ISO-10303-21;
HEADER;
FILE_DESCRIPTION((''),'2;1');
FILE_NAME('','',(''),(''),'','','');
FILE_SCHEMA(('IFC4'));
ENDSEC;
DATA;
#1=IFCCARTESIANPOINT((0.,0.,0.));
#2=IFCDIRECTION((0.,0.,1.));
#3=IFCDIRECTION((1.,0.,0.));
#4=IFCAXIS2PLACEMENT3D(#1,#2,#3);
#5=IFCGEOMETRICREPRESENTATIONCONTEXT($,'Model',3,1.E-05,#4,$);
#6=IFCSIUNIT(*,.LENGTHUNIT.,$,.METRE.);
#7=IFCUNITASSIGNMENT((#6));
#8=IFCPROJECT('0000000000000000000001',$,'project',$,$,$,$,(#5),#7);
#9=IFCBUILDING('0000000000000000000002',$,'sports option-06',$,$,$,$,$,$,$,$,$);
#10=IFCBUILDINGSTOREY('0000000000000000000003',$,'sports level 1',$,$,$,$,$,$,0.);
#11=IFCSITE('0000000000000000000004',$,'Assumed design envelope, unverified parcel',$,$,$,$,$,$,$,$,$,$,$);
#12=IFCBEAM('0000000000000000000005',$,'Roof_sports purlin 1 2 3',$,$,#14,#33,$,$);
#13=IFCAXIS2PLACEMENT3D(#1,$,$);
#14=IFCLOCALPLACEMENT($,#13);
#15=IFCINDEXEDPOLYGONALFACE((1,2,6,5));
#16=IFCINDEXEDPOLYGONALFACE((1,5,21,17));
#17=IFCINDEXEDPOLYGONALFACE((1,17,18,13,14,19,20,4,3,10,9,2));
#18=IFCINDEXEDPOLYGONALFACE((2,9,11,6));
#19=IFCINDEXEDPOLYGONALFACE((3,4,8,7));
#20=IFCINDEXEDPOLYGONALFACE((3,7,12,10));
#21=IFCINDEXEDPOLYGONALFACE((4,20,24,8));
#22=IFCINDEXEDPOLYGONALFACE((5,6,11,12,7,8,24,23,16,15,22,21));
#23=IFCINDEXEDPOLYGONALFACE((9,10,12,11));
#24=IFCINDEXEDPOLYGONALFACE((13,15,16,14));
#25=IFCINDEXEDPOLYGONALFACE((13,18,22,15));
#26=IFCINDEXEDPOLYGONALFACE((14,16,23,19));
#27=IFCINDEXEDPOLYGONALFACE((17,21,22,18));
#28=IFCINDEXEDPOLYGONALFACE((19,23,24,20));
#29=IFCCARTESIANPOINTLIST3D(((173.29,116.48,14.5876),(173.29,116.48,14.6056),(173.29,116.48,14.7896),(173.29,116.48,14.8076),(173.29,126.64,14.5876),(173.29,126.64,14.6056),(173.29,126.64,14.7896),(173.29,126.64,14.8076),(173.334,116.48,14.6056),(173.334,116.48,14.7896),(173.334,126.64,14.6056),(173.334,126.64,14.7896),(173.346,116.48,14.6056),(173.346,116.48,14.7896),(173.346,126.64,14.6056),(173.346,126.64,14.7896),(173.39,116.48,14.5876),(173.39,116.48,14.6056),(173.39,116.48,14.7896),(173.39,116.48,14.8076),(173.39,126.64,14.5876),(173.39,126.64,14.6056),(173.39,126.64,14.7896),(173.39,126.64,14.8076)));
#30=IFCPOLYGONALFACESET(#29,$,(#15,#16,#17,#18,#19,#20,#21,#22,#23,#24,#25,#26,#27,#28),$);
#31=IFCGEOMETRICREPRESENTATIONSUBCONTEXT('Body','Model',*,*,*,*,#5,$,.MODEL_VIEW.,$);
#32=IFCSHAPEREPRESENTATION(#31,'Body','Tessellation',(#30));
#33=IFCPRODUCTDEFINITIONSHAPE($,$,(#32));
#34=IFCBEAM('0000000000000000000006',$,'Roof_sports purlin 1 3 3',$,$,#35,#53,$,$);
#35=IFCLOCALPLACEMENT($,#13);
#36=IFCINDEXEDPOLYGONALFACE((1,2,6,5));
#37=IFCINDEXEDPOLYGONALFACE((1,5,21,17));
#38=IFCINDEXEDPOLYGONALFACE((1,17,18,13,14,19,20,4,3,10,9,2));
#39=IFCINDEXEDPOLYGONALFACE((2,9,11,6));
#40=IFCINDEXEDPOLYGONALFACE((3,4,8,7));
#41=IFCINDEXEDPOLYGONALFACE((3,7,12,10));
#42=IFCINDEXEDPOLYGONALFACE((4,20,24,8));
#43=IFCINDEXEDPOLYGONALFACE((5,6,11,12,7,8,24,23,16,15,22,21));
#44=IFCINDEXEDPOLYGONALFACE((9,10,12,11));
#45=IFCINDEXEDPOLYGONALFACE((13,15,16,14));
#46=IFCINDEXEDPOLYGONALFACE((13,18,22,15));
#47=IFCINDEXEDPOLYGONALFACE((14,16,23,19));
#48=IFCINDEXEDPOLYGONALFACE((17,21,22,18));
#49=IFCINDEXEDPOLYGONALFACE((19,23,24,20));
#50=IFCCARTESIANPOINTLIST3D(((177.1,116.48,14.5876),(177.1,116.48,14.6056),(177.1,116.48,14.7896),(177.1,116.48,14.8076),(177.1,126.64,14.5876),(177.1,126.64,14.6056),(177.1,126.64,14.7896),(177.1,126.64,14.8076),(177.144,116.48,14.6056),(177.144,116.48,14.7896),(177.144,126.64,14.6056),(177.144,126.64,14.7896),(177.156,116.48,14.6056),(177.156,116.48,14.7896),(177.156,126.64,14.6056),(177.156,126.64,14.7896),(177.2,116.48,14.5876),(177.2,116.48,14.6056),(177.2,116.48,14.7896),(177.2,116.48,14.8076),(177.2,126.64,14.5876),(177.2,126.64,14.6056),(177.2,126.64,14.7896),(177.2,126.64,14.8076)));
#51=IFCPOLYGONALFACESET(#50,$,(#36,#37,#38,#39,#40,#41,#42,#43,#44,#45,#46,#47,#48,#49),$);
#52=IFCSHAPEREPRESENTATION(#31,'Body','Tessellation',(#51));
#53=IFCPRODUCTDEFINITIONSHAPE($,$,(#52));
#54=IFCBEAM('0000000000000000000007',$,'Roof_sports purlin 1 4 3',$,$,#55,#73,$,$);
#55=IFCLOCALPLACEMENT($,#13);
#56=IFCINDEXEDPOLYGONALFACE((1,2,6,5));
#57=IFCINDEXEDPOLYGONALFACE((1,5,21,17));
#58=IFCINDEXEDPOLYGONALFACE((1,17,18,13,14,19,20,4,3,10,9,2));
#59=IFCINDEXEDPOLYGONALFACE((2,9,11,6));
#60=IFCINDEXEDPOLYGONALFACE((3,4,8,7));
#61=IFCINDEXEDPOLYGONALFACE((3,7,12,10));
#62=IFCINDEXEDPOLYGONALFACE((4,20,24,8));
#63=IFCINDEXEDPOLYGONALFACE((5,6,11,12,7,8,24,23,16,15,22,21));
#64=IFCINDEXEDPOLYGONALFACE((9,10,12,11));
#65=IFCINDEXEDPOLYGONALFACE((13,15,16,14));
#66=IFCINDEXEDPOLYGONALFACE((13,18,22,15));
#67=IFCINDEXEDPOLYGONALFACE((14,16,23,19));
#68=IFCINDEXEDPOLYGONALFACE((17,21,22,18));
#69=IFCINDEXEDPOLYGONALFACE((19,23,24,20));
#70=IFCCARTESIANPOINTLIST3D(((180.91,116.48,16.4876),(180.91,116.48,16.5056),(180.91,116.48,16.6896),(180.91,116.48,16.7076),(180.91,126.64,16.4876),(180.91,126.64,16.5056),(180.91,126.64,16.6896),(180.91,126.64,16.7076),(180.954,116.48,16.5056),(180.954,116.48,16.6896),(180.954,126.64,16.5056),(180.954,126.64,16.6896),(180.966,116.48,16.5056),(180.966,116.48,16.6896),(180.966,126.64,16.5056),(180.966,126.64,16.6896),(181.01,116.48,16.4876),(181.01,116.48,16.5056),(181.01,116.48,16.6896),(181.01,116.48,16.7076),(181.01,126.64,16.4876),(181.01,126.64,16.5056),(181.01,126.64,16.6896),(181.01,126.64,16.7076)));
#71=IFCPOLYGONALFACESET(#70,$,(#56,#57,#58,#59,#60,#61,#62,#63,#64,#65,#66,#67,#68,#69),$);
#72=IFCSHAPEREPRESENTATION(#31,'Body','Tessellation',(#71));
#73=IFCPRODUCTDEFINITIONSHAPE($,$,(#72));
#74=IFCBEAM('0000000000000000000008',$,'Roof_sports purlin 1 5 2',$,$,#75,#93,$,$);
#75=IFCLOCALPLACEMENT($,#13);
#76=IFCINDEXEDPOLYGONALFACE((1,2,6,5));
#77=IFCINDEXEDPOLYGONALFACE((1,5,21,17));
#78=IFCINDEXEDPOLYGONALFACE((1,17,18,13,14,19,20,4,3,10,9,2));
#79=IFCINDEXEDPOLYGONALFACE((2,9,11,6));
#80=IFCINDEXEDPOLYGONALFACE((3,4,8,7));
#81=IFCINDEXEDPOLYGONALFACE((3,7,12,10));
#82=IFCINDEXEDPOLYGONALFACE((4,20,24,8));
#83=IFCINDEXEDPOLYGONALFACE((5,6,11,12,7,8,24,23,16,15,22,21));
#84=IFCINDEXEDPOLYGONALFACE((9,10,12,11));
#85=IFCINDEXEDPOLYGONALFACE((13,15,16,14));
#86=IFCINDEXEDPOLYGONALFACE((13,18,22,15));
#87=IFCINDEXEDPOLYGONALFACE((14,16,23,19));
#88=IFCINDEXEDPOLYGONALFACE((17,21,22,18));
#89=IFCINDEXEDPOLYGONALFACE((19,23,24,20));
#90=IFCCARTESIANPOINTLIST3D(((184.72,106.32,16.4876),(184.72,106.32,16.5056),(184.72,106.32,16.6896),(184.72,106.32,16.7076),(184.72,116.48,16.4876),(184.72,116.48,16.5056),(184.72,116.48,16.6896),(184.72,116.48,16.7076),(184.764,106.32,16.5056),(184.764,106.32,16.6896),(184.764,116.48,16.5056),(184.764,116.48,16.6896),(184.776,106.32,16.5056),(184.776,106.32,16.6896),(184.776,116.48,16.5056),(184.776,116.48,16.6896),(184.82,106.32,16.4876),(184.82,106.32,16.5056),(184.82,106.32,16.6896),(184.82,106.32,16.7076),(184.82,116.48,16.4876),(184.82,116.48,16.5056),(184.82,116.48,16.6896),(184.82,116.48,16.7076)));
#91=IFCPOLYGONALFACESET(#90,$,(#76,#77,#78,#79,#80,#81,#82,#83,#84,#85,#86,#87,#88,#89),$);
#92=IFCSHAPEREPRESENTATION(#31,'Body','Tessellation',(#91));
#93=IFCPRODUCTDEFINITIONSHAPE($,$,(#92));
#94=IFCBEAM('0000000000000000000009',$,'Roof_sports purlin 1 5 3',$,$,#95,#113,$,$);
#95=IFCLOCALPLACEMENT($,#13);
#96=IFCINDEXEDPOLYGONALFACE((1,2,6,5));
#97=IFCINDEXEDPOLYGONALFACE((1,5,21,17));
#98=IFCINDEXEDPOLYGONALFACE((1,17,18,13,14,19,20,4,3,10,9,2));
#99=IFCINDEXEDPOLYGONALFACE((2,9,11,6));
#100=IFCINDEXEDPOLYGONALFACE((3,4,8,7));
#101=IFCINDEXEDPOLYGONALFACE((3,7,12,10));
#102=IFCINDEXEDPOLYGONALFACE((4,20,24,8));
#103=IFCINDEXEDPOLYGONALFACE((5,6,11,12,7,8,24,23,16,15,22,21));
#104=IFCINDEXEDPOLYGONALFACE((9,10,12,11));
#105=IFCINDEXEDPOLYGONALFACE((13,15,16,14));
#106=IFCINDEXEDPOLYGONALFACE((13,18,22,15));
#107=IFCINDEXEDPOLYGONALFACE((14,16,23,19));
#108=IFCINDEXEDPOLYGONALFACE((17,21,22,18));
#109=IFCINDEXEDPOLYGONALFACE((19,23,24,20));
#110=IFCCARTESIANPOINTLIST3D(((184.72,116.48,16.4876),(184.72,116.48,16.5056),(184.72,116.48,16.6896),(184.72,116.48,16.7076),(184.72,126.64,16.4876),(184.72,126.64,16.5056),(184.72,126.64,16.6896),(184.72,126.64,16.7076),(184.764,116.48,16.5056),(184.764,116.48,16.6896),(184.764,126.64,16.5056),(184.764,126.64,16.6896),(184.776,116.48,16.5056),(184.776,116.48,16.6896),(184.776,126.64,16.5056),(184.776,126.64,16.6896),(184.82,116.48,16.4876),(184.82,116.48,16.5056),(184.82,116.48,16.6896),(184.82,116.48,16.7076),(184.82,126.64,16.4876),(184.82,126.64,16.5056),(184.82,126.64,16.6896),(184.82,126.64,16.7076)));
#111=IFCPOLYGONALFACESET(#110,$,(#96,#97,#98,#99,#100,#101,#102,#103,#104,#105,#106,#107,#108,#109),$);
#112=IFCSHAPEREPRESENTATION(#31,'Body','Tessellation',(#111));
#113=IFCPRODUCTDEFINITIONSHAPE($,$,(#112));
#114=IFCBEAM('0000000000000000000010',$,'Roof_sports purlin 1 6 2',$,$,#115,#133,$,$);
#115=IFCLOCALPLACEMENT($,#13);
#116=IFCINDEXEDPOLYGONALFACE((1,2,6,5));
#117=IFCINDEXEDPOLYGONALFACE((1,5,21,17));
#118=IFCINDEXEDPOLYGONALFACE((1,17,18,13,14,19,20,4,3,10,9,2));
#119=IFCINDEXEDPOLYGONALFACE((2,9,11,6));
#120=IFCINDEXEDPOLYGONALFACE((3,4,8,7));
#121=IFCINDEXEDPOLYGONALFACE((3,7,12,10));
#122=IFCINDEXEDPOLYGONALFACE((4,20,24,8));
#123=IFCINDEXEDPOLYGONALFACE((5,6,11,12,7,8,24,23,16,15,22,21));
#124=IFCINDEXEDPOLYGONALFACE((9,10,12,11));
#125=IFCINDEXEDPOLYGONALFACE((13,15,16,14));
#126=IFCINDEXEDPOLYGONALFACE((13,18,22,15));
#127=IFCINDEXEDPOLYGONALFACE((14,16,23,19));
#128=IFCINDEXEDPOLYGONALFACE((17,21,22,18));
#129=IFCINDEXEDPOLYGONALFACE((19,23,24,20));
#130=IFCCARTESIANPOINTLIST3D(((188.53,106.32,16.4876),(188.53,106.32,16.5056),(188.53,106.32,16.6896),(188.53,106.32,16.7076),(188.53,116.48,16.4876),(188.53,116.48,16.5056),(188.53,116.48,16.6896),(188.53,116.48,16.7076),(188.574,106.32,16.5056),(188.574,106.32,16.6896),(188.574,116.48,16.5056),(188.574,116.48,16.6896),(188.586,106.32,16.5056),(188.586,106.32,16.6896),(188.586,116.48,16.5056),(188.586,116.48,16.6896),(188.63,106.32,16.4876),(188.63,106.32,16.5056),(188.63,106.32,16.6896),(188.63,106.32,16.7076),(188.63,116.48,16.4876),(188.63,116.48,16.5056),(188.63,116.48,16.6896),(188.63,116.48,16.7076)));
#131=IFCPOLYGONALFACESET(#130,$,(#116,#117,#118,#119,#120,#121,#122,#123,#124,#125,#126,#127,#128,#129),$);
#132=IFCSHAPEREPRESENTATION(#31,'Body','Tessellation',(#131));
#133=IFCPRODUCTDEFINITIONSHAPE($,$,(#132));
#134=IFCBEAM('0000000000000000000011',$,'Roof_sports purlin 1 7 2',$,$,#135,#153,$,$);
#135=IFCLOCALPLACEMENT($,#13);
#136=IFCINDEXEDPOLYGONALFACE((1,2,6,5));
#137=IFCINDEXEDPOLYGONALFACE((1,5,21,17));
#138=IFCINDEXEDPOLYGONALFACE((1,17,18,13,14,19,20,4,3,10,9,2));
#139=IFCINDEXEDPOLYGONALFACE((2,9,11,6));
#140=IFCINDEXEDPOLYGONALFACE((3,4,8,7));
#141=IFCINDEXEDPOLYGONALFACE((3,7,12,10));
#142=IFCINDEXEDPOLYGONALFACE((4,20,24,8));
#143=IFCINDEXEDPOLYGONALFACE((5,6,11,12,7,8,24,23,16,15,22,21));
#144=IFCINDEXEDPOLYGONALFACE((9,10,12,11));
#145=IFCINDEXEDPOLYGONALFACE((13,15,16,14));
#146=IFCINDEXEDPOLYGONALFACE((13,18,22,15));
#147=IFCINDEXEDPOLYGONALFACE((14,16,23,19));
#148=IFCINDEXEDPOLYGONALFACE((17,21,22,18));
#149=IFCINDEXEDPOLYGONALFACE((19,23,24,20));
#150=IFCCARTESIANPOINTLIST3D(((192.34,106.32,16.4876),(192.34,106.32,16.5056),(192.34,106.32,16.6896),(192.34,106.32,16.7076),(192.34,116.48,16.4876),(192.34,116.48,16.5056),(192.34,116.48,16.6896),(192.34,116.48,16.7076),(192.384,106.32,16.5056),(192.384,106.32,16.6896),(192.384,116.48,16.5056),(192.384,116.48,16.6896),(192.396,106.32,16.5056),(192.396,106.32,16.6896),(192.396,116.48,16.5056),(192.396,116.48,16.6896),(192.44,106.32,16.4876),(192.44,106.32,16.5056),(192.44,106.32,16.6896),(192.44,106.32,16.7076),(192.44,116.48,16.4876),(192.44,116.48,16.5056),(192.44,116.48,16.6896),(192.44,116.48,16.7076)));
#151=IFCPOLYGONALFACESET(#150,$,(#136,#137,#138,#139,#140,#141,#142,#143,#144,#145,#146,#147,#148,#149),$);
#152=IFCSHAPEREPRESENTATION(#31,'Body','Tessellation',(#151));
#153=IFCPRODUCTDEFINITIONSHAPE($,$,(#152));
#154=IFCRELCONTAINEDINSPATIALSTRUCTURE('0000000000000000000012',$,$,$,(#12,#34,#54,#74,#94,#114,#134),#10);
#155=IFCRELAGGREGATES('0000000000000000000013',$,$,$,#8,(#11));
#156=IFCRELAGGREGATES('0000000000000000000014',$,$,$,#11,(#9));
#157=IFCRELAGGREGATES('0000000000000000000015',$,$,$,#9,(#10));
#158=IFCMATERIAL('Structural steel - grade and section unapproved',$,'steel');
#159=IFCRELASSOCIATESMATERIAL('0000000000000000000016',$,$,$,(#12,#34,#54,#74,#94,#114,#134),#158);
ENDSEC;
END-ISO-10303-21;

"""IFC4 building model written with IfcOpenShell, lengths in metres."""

from ifc_helpers import new_model, si_unit, frame, origin_with_axes, place, context, subcontext, project, spatial, i_section, extrude, material, element, save


model = new_model("IFC4")

# Units and contexts
model_context = context("Model", 3, precision=1e-05, world=origin_with_axes())
body_context = subcontext(model_context, "Body", "Model", "MODEL_VIEW")
ifc_project = project(units=[si_unit("LENGTHUNIT", "METRE")], contexts=[model_context])

# Site, building, storey
site = spatial("IfcSite", under=ifc_project, Name="Assumed design envelope, unverified parcel")
building = spatial("IfcBuilding", under=site, Name="sports option-06")
storey = spatial("IfcBuildingStorey", under=building, Name="sports level 1", Elevation=0.0)

# Shared definitions
ifc_material = material(Name="Structural steel - grade and section unapproved", Category="steel")

# Beams
for number, where, z_axis, x_axis, name in (
    (1, (173.34, 116.48, 14.6976), (0.0, 1.0, 0.0), (-1.0, 0.0, 0.0), "Roof_sports purlin 1 2 3"),
    (2, (177.15, 116.48, 14.6976), (0.0, 1.0, 0.0), (-1.0, 0.0, 0.0), "Roof_sports purlin 1 3 3"),
    (3, (180.96, 116.48, 16.5976), (0.0, 1.0, 0.0), (-1.0, 0.0, 0.0), "Roof_sports purlin 1 4 3"),
):
    element("IfcBeam", number, at=place(None, frame(where, z_axis=z_axis, x_axis=x_axis)), inside=storey, material=ifc_material, Name=name, context=body_context, shape_type="SweptSolid", body=[
        extrude(i_section(OverallWidth=0.1, OverallDepth=0.22, WebThickness=0.012, FlangeThickness=0.018, FilletRadius=0.0), origin_with_axes(), (0.0, 0.0, 1.0), 10.16),
    ])
beam_1_placement = place(None, frame((184.77, 106.32, 16.5976), z_axis=(0.0, 1.0, 0.0), x_axis=(-1.0, 0.0, 0.0)))
element("IfcBeam", 4, at=beam_1_placement, inside=storey, material=ifc_material, Name="Roof_sports purlin 1 5 2", context=body_context, shape_type="SweptSolid", body=[
    extrude(i_section(OverallWidth=0.1, OverallDepth=0.22, WebThickness=0.012, FlangeThickness=0.018, FilletRadius=0.0), origin_with_axes(), (0.0, 0.0, 1.0), 10.16),
])
beam_2_placement = place(None, frame((184.77, 116.48, 16.5976), z_axis=(0.0, 1.0, 0.0), x_axis=(-1.0, 0.0, 0.0)))
element("IfcBeam", 5, at=beam_2_placement, inside=storey, material=ifc_material, Name="Roof_sports purlin 1 5 3", context=body_context, shape_type="SweptSolid", body=[
    extrude(i_section(OverallWidth=0.1, OverallDepth=0.22, WebThickness=0.012, FlangeThickness=0.018, FilletRadius=0.0), origin_with_axes(), (0.0, 0.0, 1.0), 10.16),
])
for number, where, z_axis, x_axis, name in (
    (6, (188.58, 106.32, 16.5976), (0.0, 1.0, 0.0), (-1.0, 0.0, 0.0), "Roof_sports purlin 1 6 2"),
    (7, (192.39, 106.32, 16.5976), (0.0, 1.0, 0.0), (-1.0, 0.0, 0.0), "Roof_sports purlin 1 7 2"),
):
    element("IfcBeam", number, at=place(None, frame(where, z_axis=z_axis, x_axis=x_axis)), inside=storey, material=ifc_material, Name=name, context=body_context, shape_type="SweptSolid", body=[
        extrude(i_section(OverallWidth=0.1, OverallDepth=0.22, WebThickness=0.012, FlangeThickness=0.018, FilletRadius=0.0), origin_with_axes(), (0.0, 0.0, 1.0), 10.16),
    ])

save(model, "model.ifc")
